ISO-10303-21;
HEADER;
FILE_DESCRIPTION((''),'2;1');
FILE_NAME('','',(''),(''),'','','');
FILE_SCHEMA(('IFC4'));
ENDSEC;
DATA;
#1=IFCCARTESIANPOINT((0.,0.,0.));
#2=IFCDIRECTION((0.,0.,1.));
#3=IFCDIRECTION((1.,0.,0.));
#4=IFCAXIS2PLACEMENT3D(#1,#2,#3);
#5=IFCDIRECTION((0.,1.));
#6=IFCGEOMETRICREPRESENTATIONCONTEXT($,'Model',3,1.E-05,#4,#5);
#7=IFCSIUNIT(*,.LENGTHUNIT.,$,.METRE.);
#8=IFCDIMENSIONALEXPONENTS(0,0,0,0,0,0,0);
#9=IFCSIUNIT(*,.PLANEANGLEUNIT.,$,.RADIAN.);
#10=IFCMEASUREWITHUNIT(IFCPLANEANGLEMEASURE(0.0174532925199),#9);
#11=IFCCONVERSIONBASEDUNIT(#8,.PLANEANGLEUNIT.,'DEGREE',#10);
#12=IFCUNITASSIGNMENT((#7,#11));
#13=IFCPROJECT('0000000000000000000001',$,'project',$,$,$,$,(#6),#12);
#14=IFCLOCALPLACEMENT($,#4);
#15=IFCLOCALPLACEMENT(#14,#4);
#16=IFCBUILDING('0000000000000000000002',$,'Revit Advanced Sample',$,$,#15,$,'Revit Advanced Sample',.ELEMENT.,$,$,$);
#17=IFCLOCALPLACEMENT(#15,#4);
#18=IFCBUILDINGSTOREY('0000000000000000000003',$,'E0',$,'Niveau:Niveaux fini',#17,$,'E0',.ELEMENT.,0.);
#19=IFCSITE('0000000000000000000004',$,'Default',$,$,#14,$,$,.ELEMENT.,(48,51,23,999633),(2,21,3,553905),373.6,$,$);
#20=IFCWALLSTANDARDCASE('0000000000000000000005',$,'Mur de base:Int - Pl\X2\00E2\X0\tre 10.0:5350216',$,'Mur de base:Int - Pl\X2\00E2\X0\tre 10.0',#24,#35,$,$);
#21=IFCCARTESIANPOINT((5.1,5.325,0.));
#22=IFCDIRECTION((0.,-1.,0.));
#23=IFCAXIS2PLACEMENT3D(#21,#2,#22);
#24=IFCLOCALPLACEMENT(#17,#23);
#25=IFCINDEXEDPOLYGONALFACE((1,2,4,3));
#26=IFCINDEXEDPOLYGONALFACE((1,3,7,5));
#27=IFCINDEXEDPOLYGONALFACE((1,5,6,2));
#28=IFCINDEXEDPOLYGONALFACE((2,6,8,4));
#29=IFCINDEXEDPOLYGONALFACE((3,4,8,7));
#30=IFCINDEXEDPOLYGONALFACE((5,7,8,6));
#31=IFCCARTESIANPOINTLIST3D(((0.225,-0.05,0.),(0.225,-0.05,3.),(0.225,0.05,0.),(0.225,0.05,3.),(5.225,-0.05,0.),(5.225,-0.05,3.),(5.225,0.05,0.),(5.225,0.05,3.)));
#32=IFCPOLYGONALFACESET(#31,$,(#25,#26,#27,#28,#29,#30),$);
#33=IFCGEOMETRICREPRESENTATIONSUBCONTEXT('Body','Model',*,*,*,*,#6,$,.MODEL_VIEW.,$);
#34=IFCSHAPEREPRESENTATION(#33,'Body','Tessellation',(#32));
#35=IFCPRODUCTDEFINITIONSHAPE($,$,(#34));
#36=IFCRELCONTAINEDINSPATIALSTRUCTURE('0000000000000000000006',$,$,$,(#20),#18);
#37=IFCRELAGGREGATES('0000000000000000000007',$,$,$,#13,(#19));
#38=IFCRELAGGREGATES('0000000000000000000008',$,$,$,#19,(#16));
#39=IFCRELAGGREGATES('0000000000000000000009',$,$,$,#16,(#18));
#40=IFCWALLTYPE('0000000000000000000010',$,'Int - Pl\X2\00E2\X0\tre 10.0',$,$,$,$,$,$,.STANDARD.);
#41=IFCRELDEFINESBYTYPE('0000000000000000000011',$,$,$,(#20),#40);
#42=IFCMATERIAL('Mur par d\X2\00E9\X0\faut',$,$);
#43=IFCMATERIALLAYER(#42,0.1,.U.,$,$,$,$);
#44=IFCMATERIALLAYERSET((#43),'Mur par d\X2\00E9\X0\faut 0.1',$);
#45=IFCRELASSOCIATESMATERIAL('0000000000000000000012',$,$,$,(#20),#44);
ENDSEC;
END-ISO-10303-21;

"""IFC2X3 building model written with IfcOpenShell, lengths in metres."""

from ifc_helpers import new_model, entity, si_unit, converted_unit, direction, frame, origin_with_axes, place, context, subcontext, project, spatial, polyline, outline, extrude, material, layer, layer_set, layer_usage, type_object, element, save


model = new_model("IFC2X3")

# Units and contexts
model_context = context("Model", 3, precision=1e-05, world=origin_with_axes(), true_north=direction((0.0, 1.0)))
body_context = subcontext(model_context, "Body", "Model", "MODEL_VIEW")
ifc_project = project(units=[si_unit("LENGTHUNIT", "METRE"), converted_unit("PLANEANGLEUNIT", "DEGREE", entity("IfcPlaneAngleMeasure", 0.0174532925199), si_unit("PLANEANGLEUNIT", "RADIAN"), dimensions=[0, 0, 0, 0, 0, 0, 0])], contexts=[model_context])

# Site, building, storey
site_placement = place(None, origin_with_axes())
site = spatial("IfcSite", under=ifc_project, at=site_placement, Name="Default", CompositionType="ELEMENT", RefLatitude=(48, 51, 23, 999633), RefLongitude=(2, 21, 3, 553905), RefElevation=373.6)
building_placement = place(site_placement, origin_with_axes())
building = spatial("IfcBuilding", under=site, at=building_placement, Name="Revit Advanced Sample", LongName="Revit Advanced Sample", CompositionType="ELEMENT")
storey_placement = place(building_placement, origin_with_axes())
storey = spatial("IfcBuildingStorey", under=building, at=storey_placement, Name="E0", ObjectType="Niveau:Niveaux fini", LongName="E0", CompositionType="ELEMENT", Elevation=0.0)

# Wall
ifc_material_1 = material(Name="Mur par défaut")
ifc_layer_1 = layer(ifc_material_1, 0.1, ventilated="UNKNOWN")
ifc_layer_set_1 = layer_set([ifc_layer_1], Name="Mur par défaut 0.1")
ifc_layer_usage_1 = layer_usage(ifc_layer_set_1, "AXIS2", "POSITIVE", -0.05)
wall_type_1 = type_object("IfcWallType", Name="Int - Plâtre 10.0", PredefinedType="STANDARD")
wall_1_placement = place(storey_placement, frame((5.1, 5.325, 0.0), z_axis=(0.0, 0.0, 1.0), x_axis=(0.0, -1.0, 0.0)))
element("IfcWallStandardCase", 1, at=wall_1_placement, inside=storey, type_object=wall_type_1, material=ifc_layer_usage_1, Name="Mur de base:Int - Plâtre 10.0:5350216", ObjectType="Mur de base:Int - Plâtre 10.0", context=body_context, shape_type="SweptSolid", body=[
    extrude(outline(polyline([(0.225, -0.05), (5.225, -0.05), (5.225, 0.05), (0.225, 0.05), (0.225, -0.05)])), origin_with_axes(), (0.0, 0.0, 1.0), 3.0),
])

save(model, "model.ifc")
